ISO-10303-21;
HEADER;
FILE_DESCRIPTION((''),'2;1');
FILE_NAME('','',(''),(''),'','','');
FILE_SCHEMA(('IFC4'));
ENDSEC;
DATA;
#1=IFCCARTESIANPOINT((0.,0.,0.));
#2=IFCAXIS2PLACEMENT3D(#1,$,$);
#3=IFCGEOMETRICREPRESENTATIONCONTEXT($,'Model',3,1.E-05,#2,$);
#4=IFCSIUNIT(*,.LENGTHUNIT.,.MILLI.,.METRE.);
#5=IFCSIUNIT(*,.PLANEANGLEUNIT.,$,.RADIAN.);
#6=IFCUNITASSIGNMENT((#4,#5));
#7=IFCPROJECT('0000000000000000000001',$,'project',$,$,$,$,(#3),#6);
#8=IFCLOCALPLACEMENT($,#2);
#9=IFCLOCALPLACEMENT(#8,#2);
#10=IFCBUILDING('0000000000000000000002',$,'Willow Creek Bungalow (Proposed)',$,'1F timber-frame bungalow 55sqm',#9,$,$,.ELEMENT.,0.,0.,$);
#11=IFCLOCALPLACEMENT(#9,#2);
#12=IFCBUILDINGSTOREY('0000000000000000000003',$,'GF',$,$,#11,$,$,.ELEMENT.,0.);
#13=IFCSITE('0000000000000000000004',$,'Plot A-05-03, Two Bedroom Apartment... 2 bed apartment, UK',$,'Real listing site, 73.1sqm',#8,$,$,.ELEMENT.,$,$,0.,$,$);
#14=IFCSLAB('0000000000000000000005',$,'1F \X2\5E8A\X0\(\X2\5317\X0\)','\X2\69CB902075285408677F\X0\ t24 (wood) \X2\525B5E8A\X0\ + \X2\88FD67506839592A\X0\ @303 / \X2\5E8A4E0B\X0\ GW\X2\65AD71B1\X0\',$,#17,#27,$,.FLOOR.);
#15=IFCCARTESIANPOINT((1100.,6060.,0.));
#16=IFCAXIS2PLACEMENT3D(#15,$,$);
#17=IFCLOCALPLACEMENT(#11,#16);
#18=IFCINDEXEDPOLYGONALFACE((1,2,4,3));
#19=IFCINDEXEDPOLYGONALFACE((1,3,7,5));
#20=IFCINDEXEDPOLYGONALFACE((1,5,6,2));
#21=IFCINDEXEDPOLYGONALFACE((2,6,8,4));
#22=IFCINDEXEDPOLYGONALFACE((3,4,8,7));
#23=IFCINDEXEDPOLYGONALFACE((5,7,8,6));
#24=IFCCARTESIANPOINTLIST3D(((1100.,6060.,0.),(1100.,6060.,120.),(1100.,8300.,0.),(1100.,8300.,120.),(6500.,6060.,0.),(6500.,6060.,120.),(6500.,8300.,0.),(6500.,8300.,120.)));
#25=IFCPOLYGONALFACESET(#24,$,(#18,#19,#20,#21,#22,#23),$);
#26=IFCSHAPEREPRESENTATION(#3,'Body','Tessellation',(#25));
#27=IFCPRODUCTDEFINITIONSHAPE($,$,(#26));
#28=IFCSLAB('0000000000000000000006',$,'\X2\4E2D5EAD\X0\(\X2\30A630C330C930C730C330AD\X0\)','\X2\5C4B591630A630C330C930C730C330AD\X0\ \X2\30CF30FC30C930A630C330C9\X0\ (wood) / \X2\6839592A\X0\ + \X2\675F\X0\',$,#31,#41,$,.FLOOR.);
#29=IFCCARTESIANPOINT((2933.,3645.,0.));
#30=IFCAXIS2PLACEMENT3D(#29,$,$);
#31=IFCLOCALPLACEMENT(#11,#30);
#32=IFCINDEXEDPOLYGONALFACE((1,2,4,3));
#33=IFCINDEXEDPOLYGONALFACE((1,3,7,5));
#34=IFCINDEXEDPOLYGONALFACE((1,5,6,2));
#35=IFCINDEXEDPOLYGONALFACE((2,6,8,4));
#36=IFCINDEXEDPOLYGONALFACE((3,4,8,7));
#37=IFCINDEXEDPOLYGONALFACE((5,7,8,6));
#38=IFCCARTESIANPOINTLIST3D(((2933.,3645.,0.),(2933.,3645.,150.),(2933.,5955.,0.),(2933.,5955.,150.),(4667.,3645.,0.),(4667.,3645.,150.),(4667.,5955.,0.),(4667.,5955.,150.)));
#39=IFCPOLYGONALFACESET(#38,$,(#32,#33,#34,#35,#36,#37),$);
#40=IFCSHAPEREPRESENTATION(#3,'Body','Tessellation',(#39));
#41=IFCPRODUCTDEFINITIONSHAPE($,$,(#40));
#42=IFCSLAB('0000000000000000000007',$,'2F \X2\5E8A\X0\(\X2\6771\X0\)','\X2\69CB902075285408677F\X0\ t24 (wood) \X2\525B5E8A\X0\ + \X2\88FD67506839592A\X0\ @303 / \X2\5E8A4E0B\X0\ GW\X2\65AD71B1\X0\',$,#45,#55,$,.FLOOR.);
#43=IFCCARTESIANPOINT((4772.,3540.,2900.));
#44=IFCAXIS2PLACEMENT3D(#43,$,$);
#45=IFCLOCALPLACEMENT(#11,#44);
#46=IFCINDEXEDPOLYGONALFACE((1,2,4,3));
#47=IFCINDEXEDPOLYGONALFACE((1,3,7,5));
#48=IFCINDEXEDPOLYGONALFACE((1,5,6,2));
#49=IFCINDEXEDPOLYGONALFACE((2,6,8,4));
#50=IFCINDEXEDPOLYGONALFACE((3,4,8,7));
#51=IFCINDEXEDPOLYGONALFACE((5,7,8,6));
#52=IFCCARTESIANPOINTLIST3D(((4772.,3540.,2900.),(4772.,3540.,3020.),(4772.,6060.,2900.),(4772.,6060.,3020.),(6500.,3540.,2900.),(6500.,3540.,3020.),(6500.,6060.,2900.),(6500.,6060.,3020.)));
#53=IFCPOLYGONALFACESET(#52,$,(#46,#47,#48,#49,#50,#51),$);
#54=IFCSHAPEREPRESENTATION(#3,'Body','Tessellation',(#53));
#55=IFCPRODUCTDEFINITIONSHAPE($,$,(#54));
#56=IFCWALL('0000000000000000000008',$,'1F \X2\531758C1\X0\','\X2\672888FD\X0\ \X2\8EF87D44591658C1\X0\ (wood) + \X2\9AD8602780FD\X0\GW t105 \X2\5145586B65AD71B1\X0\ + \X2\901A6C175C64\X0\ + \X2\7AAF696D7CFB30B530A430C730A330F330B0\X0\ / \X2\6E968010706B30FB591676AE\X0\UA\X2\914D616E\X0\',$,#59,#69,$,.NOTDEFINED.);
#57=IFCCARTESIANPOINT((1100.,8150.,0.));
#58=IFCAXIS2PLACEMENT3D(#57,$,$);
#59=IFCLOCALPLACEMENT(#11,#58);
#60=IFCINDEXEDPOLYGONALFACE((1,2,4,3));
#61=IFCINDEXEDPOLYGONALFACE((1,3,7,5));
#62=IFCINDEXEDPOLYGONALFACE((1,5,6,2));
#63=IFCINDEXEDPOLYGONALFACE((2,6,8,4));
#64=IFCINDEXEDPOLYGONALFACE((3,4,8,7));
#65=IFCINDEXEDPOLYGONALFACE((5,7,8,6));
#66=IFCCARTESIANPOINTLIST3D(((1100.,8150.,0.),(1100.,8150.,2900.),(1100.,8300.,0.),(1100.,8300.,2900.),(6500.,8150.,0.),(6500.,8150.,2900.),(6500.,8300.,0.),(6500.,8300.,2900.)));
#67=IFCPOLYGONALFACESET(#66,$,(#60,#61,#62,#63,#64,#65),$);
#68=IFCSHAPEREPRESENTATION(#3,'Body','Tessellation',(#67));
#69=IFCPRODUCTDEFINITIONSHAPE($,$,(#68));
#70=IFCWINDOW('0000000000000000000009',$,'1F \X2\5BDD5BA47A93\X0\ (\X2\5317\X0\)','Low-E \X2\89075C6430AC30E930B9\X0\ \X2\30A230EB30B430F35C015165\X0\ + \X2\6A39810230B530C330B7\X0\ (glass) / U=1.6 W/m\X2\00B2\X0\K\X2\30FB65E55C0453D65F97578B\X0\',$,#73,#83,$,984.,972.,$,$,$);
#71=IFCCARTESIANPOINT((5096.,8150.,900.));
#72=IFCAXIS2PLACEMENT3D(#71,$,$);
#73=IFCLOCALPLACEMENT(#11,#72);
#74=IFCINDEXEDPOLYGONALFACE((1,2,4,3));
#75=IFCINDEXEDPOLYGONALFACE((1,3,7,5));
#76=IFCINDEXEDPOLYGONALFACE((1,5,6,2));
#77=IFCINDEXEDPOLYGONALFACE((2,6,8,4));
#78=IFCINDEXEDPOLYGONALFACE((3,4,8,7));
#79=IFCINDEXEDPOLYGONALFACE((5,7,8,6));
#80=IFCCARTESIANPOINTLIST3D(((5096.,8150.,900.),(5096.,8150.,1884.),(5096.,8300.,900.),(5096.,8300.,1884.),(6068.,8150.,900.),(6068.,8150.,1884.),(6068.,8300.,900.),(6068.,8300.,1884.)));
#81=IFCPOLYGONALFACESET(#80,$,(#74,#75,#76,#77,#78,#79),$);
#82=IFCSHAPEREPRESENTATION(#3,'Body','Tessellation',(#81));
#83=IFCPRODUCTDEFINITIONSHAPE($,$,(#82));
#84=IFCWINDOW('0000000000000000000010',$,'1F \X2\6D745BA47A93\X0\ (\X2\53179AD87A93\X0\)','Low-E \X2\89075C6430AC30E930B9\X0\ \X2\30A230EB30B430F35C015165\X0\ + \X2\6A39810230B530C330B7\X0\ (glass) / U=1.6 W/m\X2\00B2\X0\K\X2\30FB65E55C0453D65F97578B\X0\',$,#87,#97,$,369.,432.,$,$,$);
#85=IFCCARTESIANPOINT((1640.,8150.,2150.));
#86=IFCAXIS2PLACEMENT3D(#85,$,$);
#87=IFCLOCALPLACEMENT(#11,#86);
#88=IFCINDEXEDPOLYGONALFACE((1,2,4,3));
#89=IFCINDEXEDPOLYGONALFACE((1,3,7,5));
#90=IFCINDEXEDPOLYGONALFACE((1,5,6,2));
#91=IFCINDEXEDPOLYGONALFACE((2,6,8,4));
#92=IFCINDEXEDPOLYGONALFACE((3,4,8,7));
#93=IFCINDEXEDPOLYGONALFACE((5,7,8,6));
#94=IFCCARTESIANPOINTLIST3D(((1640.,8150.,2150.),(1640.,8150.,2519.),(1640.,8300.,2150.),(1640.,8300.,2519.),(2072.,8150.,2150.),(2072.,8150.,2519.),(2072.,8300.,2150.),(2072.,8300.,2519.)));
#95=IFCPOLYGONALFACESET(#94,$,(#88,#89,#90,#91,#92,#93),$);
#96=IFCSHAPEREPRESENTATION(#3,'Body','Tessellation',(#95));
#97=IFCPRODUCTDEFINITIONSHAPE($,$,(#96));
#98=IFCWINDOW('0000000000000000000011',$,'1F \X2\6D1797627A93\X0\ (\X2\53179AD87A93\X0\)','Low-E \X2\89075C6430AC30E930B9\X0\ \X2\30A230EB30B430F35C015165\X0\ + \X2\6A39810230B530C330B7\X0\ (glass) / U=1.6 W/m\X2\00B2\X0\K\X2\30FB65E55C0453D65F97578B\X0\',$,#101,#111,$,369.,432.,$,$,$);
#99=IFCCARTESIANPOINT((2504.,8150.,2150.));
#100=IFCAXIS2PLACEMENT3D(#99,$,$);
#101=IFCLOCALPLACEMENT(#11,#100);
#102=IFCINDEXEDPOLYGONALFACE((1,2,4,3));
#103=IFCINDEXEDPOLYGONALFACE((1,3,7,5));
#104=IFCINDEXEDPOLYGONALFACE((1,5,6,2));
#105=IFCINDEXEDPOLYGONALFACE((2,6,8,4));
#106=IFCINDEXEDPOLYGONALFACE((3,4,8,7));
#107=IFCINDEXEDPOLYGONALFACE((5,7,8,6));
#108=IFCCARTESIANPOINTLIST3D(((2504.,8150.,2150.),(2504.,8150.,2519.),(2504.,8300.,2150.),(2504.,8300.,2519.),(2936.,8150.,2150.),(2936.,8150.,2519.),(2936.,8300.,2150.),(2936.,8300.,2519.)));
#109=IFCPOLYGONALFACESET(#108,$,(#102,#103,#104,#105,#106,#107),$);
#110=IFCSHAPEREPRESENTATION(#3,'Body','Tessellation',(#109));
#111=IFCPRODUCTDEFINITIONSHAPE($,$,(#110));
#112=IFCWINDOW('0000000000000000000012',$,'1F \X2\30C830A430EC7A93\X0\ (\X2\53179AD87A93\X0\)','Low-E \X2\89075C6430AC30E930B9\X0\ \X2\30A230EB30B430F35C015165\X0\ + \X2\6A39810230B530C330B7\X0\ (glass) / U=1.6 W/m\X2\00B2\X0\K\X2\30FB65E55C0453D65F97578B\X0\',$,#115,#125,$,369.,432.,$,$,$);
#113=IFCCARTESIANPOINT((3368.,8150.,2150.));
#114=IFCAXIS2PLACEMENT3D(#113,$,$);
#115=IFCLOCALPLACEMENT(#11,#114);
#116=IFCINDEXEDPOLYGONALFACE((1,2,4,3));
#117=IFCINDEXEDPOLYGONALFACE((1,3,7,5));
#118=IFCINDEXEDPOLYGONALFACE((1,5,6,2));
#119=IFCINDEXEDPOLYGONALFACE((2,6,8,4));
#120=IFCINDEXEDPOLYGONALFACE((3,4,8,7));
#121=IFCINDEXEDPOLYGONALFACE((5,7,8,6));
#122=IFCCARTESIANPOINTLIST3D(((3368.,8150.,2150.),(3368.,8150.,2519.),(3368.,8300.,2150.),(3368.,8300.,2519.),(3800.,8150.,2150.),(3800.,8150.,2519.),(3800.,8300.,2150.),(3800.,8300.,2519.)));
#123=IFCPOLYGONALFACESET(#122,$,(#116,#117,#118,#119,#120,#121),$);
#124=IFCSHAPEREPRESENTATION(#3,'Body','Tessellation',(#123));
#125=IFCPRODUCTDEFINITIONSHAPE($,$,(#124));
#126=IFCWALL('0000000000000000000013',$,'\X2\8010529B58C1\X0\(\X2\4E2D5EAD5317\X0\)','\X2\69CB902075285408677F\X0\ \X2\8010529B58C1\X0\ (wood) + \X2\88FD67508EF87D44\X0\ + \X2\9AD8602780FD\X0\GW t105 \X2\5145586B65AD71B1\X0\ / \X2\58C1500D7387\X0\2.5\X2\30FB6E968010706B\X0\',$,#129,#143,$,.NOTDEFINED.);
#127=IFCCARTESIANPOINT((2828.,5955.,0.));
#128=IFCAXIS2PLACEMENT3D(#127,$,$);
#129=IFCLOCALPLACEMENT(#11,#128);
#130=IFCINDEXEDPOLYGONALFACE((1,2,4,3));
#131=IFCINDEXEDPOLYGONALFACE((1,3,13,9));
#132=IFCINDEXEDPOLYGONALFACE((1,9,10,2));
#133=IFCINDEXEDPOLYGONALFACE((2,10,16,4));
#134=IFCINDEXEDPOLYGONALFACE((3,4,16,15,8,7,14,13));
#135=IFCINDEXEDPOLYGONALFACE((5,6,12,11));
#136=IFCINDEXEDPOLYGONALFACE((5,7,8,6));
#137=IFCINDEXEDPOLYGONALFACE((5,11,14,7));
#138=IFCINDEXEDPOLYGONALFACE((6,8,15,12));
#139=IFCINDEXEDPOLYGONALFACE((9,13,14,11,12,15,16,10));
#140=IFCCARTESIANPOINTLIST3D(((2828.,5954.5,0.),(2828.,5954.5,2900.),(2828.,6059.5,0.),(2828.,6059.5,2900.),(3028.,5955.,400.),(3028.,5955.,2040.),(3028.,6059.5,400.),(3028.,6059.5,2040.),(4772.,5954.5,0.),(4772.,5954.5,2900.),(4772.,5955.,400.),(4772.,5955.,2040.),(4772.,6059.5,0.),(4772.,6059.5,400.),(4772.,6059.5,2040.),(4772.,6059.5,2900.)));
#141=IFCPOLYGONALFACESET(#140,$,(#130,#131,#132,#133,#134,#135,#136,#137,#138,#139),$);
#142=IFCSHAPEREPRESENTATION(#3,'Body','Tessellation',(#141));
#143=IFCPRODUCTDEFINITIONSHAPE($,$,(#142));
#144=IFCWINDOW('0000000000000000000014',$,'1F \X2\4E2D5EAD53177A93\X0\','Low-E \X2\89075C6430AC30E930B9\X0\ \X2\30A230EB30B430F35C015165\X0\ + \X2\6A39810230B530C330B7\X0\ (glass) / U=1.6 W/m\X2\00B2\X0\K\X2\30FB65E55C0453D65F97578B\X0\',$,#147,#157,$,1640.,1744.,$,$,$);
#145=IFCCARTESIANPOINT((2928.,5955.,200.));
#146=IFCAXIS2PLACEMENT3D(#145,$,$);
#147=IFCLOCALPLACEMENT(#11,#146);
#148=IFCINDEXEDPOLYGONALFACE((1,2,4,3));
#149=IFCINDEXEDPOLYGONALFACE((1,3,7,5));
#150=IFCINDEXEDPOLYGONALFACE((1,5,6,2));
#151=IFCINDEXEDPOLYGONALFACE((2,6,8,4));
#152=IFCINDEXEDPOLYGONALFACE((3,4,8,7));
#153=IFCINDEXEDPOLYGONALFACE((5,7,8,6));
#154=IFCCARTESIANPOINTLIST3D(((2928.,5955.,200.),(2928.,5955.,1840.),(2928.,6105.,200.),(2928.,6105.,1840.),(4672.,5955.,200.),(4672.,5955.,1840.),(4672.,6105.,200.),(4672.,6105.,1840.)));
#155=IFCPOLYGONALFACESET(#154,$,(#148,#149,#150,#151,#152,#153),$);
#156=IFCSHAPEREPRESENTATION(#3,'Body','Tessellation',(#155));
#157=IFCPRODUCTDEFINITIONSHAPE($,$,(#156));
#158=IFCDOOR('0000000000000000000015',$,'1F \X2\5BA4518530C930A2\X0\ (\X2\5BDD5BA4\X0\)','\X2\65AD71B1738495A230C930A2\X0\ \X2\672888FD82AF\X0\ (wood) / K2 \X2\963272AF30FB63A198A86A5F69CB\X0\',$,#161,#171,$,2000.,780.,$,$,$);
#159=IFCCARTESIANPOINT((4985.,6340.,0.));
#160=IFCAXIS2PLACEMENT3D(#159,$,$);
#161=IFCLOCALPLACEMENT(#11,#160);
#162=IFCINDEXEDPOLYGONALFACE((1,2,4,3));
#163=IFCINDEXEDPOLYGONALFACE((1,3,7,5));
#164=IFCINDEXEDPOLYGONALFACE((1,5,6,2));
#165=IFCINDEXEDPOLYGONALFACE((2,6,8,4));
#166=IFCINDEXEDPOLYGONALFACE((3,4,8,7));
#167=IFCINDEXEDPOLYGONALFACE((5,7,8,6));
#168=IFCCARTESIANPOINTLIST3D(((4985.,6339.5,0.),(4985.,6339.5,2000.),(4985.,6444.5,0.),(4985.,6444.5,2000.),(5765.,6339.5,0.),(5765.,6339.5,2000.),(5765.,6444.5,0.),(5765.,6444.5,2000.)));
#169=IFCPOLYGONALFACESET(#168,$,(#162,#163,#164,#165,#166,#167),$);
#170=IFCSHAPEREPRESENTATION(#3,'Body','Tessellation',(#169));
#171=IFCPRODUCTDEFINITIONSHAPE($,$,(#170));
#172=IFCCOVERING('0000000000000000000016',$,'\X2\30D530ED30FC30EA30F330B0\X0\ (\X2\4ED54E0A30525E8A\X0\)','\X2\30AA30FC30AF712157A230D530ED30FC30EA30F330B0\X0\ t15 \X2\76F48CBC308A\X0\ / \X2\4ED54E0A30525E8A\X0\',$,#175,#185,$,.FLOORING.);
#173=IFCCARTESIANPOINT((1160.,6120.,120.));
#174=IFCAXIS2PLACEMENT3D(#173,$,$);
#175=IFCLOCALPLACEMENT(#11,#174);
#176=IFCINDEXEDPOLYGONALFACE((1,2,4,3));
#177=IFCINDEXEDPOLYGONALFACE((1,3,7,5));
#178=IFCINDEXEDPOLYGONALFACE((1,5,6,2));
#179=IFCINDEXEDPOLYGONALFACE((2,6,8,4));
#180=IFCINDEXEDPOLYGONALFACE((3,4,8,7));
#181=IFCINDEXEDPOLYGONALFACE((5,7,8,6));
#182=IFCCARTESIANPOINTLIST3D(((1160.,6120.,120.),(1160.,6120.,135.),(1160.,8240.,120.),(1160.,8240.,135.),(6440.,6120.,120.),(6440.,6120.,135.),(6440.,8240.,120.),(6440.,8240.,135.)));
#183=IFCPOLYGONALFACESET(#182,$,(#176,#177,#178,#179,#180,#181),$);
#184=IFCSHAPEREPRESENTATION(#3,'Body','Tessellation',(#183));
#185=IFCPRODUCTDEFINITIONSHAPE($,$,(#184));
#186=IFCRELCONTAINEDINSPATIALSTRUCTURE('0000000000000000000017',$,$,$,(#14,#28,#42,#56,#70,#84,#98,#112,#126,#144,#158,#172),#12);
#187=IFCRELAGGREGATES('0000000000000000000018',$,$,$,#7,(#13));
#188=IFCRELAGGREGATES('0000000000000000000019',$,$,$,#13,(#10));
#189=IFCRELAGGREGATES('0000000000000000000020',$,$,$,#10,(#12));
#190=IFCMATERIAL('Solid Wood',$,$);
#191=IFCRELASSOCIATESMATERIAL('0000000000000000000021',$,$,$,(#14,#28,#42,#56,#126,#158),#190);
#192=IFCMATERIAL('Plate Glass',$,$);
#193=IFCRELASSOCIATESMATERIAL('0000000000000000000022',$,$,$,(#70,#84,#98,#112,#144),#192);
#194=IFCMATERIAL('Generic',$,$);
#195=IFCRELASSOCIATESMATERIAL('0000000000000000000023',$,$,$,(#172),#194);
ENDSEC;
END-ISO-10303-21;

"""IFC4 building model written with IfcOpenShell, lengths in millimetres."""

from ifc_helpers import new_model, si_unit, frame, frame_2d, origin, place, context, project, spatial, rectangle, extrude, material, element, fill, save


model = new_model("IFC4")

# Units and contexts
model_context = context("Model", 3, precision=1e-05, world=origin())
ifc_project = project(units=[si_unit("LENGTHUNIT", "METRE", prefix="MILLI"), si_unit("PLANEANGLEUNIT", "RADIAN")], contexts=[model_context])

# Site, building, storey
site_placement = place(None, origin())
site = spatial("IfcSite", under=ifc_project, at=site_placement, Name="Plot A-05-03, Two Bedroom Apartment... 2 bed apartment, UK", ObjectType="Real listing site, 73.1sqm", CompositionType="ELEMENT", RefElevation=0.0)
building_placement = place(site_placement, origin())
building = spatial("IfcBuilding", under=site, at=building_placement, Name="Willow Creek Bungalow (Proposed)", ObjectType="1F timber-frame bungalow 55sqm", CompositionType="ELEMENT", ElevationOfRefHeight=0.0, ElevationOfTerrain=0.0)
storey_placement = place(building_placement, origin())
storey = spatial("IfcBuildingStorey", under=building, at=storey_placement, Name="GF", CompositionType="ELEMENT", Elevation=0.0)

# Slabs
ifc_material_1 = material(Name="Solid Wood")
slab_1_placement = place(storey_placement, frame((1100.0, 6060.0, 0.0)))
element("IfcSlab", 1, at=slab_1_placement, inside=storey, material=ifc_material_1, Name="1F 床(北)", Description="構造用合板 t24 (wood) 剛床 + 製材根太 @303 / 床下 GW断熱", PredefinedType="FLOOR", context=model_context, shape_type="SweptSolid", body=[
    extrude(rectangle(XDim=5400.0, YDim=2240.0, at=frame_2d((2700.0, 1120.0))), frame((1100.0, 6060.0, 0.0)), (0.0, 0.0, 1.0), 120.0),
])
slab_2_placement = place(storey_placement, frame((2933.0, 3645.0, 0.0)))
element("IfcSlab", 2, at=slab_2_placement, inside=storey, material=ifc_material_1, Name="中庭(ウッドデッキ)", Description="屋外ウッドデッキ ハードウッド (wood) / 根太 + 束", PredefinedType="FLOOR", context=model_context, shape_type="SweptSolid", body=[
    extrude(rectangle(XDim=1734.0, YDim=2310.0, at=frame_2d((867.0, 1155.0))), frame((2933.0, 3645.0, 0.0)), (0.0, 0.0, 1.0), 150.0),
])
slab_3_placement = place(storey_placement, frame((4772.0, 3540.0, 2900.0)))
element("IfcSlab", 3, at=slab_3_placement, inside=storey, material=ifc_material_1, Name="2F 床(東)", Description="構造用合板 t24 (wood) 剛床 + 製材根太 @303 / 床下 GW断熱", PredefinedType="FLOOR", context=model_context, shape_type="SweptSolid", body=[
    extrude(rectangle(XDim=1728.0, YDim=2520.0, at=frame_2d((864.0, 1260.0))), frame((4772.0, 3540.0, 2900.0)), (0.0, 0.0, 1.0), 120.0),
])

# Wall, openings, windows
wall_1_placement = place(storey_placement, frame((1100.0, 8150.0, 0.0)))
wall_1 = element("IfcWall", 4, at=wall_1_placement, inside=storey, material=ifc_material_1, Name="1F 北壁", Description="木製 軸組外壁 (wood) + 高性能GW t105 充填断熱 + 通気層 + 窯業系サイディング / 準耐火・外皮UA配慮", PredefinedType="NOTDEFINED", context=model_context, shape_type="SweptSolid", body=[
    extrude(rectangle(XDim=5400.0, YDim=150.0, at=frame_2d((2700.0, 75.0))), frame((1100.0, 8150.0, 0.0)), (0.0, 0.0, 1.0), 2900.0),
])
opening_1_placement = place(storey_placement, frame((5096.0, 8150.0, 900.0)))
opening_1 = element("IfcOpeningElement", 5, at=opening_1_placement, cuts=wall_1, PredefinedType="NOTDEFINED", context=model_context, shape_type="SweptSolid", body=[
    extrude(rectangle(XDim=972.0, YDim=150.0, at=frame_2d((486.0, 75.0))), frame((5096.0, 8150.0, 900.0)), (0.0, 0.0, 1.0), 984.0),
])
opening_2_placement = place(storey_placement, frame((1640.0, 8150.0, 2150.0)))
opening_2 = element("IfcOpeningElement", 6, at=opening_2_placement, cuts=wall_1, PredefinedType="NOTDEFINED", context=model_context, shape_type="SweptSolid", body=[
    extrude(rectangle(XDim=432.0, YDim=150.0, at=frame_2d((216.0, 75.0))), frame((1640.0, 8150.0, 2150.0)), (0.0, 0.0, 1.0), 369.0),
])
opening_3_placement = place(storey_placement, frame((2504.0, 8150.0, 2150.0)))
opening_3 = element("IfcOpeningElement", 7, at=opening_3_placement, cuts=wall_1, PredefinedType="NOTDEFINED", context=model_context, shape_type="SweptSolid", body=[
    extrude(rectangle(XDim=432.0, YDim=150.0, at=frame_2d((216.0, 75.0))), frame((2504.0, 8150.0, 2150.0)), (0.0, 0.0, 1.0), 369.0),
])
opening_4_placement = place(storey_placement, frame((3368.0, 8150.0, 2150.0)))
opening_4 = element("IfcOpeningElement", 8, at=opening_4_placement, cuts=wall_1, PredefinedType="NOTDEFINED", context=model_context, shape_type="SweptSolid", body=[
    extrude(rectangle(XDim=432.0, YDim=150.0, at=frame_2d((216.0, 75.0))), frame((3368.0, 8150.0, 2150.0)), (0.0, 0.0, 1.0), 369.0),
])
ifc_material_2 = material(Name="Plate Glass")
window_1_placement = place(storey_placement, frame((5096.0, 8150.0, 900.0)))
window_1 = element("IfcWindow", 9, at=window_1_placement, inside=storey, material=ifc_material_2, Name="1F 寝室窓 (北)", Description="Low-E 複層ガラス アルゴン封入 + 樹脂サッシ (glass) / U=1.6 W/m²K・日射取得型", OverallHeight=984.0, OverallWidth=972.0, context=model_context, shape_type="SweptSolid", body=[
    extrude(rectangle(XDim=972.0, YDim=150.0, at=frame_2d((486.0, 75.0))), frame((5096.0, 8150.0, 900.0)), (0.0, 0.0, 1.0), 984.0),
])
fill(opening_1, window_1)
window_2_placement = place(storey_placement, frame((1640.0, 8150.0, 2150.0)))
window_2 = element("IfcWindow", 10, at=window_2_placement, inside=storey, material=ifc_material_2, Name="1F 浴室窓 (北高窓)", Description="Low-E 複層ガラス アルゴン封入 + 樹脂サッシ (glass) / U=1.6 W/m²K・日射取得型", OverallHeight=369.0, OverallWidth=432.0, context=model_context, shape_type="SweptSolid", body=[
    extrude(rectangle(XDim=432.0, YDim=150.0, at=frame_2d((216.0, 75.0))), frame((1640.0, 8150.0, 2150.0)), (0.0, 0.0, 1.0), 369.0),
])
fill(opening_2, window_2)
window_3_placement = place(storey_placement, frame((2504.0, 8150.0, 2150.0)))
window_3 = element("IfcWindow", 11, at=window_3_placement, inside=storey, material=ifc_material_2, Name="1F 洗面窓 (北高窓)", Description="Low-E 複層ガラス アルゴン封入 + 樹脂サッシ (glass) / U=1.6 W/m²K・日射取得型", OverallHeight=369.0, OverallWidth=432.0, context=model_context, shape_type="SweptSolid", body=[
    extrude(rectangle(XDim=432.0, YDim=150.0, at=frame_2d((216.0, 75.0))), frame((2504.0, 8150.0, 2150.0)), (0.0, 0.0, 1.0), 369.0),
])
fill(opening_3, window_3)
window_4_placement = place(storey_placement, frame((3368.0, 8150.0, 2150.0)))
window_4 = element("IfcWindow", 12, at=window_4_placement, inside=storey, material=ifc_material_2, Name="1F トイレ窓 (北高窓)", Description="Low-E 複層ガラス アルゴン封入 + 樹脂サッシ (glass) / U=1.6 W/m²K・日射取得型", OverallHeight=369.0, OverallWidth=432.0, context=model_context, shape_type="SweptSolid", body=[
    extrude(rectangle(XDim=432.0, YDim=150.0, at=frame_2d((216.0, 75.0))), frame((3368.0, 8150.0, 2150.0)), (0.0, 0.0, 1.0), 369.0),
])
fill(opening_4, window_4)

# Wall, opening, window
wall_2_placement = place(storey_placement, frame((2828.0, 5955.0, 0.0)))
wall_2 = element("IfcWall", 13, at=wall_2_placement, inside=storey, material=ifc_material_1, Name="耐力壁(中庭北)", Description="構造用合板 耐力壁 (wood) + 製材軸組 + 高性能GW t105 充填断熱 / 壁倍率2.5・準耐火", PredefinedType="NOTDEFINED", context=model_context, shape_type="SweptSolid", body=[
    extrude(rectangle(XDim=1944.0, YDim=105.0, at=frame_2d((972.0, 52.0))), frame((2828.0, 5955.0, 0.0)), (0.0, 0.0, 1.0), 2900.0),
])
opening_5_placement = place(storey_placement, frame((2928.0, 5955.0, 200.0)))
opening_5 = element("IfcOpeningElement", 14, at=opening_5_placement, cuts=wall_2, PredefinedType="NOTDEFINED", context=model_context, shape_type="SweptSolid", body=[
    extrude(rectangle(XDim=1744.0, YDim=150.0, at=frame_2d((872.0, 75.0))), frame((2928.0, 5955.0, 200.0)), (0.0, 0.0, 1.0), 1640.0),
])
window_5_placement = place(storey_placement, frame((2928.0, 5955.0, 200.0)))
window_5 = element("IfcWindow", 15, at=window_5_placement, inside=storey, material=ifc_material_2, Name="1F 中庭北窓", Description="Low-E 複層ガラス アルゴン封入 + 樹脂サッシ (glass) / U=1.6 W/m²K・日射取得型", OverallHeight=1640.0, OverallWidth=1744.0, context=model_context, shape_type="SweptSolid", body=[
    extrude(rectangle(XDim=1744.0, YDim=150.0, at=frame_2d((872.0, 75.0))), frame((2928.0, 5955.0, 200.0)), (0.0, 0.0, 1.0), 1640.0),
])
fill(opening_5, window_5)

# Door
door_1_placement = place(storey_placement, frame((4985.0, 6340.0, 0.0)))
element("IfcDoor", 16, at=door_1_placement, inside=storey, material=ifc_material_1, Name="1F 室内ドア (寝室)", Description="断熱玄関ドア 木製芯 (wood) / K2 防犯・採風機構", OverallHeight=2000.0, OverallWidth=780.0, context=model_context, shape_type="SweptSolid", body=[
    extrude(rectangle(XDim=780.0, YDim=105.0, at=frame_2d((390.0, 52.0))), frame((4985.0, 6340.0, 0.0)), (0.0, 0.0, 1.0), 2000.0),
])

# Covering
ifc_material_3 = material(Name="Generic")
covering_1_placement = place(storey_placement, frame((1160.0, 6120.0, 120.0)))
element("IfcCovering", 17, at=covering_1_placement, inside=storey, material=ifc_material_3, Name="フローリング (仕上げ床)", Description="オーク無垢フローリング t15 直貼り / 仕上げ床", PredefinedType="FLOORING", context=model_context, shape_type="SweptSolid", body=[
    extrude(rectangle(XDim=5280.0, YDim=2120.0, at=frame_2d((2640.0, 1060.0))), frame((1160.0, 6120.0, 120.0)), (0.0, 0.0, 1.0), 15.0),
])

save(model, "model.ifc")
